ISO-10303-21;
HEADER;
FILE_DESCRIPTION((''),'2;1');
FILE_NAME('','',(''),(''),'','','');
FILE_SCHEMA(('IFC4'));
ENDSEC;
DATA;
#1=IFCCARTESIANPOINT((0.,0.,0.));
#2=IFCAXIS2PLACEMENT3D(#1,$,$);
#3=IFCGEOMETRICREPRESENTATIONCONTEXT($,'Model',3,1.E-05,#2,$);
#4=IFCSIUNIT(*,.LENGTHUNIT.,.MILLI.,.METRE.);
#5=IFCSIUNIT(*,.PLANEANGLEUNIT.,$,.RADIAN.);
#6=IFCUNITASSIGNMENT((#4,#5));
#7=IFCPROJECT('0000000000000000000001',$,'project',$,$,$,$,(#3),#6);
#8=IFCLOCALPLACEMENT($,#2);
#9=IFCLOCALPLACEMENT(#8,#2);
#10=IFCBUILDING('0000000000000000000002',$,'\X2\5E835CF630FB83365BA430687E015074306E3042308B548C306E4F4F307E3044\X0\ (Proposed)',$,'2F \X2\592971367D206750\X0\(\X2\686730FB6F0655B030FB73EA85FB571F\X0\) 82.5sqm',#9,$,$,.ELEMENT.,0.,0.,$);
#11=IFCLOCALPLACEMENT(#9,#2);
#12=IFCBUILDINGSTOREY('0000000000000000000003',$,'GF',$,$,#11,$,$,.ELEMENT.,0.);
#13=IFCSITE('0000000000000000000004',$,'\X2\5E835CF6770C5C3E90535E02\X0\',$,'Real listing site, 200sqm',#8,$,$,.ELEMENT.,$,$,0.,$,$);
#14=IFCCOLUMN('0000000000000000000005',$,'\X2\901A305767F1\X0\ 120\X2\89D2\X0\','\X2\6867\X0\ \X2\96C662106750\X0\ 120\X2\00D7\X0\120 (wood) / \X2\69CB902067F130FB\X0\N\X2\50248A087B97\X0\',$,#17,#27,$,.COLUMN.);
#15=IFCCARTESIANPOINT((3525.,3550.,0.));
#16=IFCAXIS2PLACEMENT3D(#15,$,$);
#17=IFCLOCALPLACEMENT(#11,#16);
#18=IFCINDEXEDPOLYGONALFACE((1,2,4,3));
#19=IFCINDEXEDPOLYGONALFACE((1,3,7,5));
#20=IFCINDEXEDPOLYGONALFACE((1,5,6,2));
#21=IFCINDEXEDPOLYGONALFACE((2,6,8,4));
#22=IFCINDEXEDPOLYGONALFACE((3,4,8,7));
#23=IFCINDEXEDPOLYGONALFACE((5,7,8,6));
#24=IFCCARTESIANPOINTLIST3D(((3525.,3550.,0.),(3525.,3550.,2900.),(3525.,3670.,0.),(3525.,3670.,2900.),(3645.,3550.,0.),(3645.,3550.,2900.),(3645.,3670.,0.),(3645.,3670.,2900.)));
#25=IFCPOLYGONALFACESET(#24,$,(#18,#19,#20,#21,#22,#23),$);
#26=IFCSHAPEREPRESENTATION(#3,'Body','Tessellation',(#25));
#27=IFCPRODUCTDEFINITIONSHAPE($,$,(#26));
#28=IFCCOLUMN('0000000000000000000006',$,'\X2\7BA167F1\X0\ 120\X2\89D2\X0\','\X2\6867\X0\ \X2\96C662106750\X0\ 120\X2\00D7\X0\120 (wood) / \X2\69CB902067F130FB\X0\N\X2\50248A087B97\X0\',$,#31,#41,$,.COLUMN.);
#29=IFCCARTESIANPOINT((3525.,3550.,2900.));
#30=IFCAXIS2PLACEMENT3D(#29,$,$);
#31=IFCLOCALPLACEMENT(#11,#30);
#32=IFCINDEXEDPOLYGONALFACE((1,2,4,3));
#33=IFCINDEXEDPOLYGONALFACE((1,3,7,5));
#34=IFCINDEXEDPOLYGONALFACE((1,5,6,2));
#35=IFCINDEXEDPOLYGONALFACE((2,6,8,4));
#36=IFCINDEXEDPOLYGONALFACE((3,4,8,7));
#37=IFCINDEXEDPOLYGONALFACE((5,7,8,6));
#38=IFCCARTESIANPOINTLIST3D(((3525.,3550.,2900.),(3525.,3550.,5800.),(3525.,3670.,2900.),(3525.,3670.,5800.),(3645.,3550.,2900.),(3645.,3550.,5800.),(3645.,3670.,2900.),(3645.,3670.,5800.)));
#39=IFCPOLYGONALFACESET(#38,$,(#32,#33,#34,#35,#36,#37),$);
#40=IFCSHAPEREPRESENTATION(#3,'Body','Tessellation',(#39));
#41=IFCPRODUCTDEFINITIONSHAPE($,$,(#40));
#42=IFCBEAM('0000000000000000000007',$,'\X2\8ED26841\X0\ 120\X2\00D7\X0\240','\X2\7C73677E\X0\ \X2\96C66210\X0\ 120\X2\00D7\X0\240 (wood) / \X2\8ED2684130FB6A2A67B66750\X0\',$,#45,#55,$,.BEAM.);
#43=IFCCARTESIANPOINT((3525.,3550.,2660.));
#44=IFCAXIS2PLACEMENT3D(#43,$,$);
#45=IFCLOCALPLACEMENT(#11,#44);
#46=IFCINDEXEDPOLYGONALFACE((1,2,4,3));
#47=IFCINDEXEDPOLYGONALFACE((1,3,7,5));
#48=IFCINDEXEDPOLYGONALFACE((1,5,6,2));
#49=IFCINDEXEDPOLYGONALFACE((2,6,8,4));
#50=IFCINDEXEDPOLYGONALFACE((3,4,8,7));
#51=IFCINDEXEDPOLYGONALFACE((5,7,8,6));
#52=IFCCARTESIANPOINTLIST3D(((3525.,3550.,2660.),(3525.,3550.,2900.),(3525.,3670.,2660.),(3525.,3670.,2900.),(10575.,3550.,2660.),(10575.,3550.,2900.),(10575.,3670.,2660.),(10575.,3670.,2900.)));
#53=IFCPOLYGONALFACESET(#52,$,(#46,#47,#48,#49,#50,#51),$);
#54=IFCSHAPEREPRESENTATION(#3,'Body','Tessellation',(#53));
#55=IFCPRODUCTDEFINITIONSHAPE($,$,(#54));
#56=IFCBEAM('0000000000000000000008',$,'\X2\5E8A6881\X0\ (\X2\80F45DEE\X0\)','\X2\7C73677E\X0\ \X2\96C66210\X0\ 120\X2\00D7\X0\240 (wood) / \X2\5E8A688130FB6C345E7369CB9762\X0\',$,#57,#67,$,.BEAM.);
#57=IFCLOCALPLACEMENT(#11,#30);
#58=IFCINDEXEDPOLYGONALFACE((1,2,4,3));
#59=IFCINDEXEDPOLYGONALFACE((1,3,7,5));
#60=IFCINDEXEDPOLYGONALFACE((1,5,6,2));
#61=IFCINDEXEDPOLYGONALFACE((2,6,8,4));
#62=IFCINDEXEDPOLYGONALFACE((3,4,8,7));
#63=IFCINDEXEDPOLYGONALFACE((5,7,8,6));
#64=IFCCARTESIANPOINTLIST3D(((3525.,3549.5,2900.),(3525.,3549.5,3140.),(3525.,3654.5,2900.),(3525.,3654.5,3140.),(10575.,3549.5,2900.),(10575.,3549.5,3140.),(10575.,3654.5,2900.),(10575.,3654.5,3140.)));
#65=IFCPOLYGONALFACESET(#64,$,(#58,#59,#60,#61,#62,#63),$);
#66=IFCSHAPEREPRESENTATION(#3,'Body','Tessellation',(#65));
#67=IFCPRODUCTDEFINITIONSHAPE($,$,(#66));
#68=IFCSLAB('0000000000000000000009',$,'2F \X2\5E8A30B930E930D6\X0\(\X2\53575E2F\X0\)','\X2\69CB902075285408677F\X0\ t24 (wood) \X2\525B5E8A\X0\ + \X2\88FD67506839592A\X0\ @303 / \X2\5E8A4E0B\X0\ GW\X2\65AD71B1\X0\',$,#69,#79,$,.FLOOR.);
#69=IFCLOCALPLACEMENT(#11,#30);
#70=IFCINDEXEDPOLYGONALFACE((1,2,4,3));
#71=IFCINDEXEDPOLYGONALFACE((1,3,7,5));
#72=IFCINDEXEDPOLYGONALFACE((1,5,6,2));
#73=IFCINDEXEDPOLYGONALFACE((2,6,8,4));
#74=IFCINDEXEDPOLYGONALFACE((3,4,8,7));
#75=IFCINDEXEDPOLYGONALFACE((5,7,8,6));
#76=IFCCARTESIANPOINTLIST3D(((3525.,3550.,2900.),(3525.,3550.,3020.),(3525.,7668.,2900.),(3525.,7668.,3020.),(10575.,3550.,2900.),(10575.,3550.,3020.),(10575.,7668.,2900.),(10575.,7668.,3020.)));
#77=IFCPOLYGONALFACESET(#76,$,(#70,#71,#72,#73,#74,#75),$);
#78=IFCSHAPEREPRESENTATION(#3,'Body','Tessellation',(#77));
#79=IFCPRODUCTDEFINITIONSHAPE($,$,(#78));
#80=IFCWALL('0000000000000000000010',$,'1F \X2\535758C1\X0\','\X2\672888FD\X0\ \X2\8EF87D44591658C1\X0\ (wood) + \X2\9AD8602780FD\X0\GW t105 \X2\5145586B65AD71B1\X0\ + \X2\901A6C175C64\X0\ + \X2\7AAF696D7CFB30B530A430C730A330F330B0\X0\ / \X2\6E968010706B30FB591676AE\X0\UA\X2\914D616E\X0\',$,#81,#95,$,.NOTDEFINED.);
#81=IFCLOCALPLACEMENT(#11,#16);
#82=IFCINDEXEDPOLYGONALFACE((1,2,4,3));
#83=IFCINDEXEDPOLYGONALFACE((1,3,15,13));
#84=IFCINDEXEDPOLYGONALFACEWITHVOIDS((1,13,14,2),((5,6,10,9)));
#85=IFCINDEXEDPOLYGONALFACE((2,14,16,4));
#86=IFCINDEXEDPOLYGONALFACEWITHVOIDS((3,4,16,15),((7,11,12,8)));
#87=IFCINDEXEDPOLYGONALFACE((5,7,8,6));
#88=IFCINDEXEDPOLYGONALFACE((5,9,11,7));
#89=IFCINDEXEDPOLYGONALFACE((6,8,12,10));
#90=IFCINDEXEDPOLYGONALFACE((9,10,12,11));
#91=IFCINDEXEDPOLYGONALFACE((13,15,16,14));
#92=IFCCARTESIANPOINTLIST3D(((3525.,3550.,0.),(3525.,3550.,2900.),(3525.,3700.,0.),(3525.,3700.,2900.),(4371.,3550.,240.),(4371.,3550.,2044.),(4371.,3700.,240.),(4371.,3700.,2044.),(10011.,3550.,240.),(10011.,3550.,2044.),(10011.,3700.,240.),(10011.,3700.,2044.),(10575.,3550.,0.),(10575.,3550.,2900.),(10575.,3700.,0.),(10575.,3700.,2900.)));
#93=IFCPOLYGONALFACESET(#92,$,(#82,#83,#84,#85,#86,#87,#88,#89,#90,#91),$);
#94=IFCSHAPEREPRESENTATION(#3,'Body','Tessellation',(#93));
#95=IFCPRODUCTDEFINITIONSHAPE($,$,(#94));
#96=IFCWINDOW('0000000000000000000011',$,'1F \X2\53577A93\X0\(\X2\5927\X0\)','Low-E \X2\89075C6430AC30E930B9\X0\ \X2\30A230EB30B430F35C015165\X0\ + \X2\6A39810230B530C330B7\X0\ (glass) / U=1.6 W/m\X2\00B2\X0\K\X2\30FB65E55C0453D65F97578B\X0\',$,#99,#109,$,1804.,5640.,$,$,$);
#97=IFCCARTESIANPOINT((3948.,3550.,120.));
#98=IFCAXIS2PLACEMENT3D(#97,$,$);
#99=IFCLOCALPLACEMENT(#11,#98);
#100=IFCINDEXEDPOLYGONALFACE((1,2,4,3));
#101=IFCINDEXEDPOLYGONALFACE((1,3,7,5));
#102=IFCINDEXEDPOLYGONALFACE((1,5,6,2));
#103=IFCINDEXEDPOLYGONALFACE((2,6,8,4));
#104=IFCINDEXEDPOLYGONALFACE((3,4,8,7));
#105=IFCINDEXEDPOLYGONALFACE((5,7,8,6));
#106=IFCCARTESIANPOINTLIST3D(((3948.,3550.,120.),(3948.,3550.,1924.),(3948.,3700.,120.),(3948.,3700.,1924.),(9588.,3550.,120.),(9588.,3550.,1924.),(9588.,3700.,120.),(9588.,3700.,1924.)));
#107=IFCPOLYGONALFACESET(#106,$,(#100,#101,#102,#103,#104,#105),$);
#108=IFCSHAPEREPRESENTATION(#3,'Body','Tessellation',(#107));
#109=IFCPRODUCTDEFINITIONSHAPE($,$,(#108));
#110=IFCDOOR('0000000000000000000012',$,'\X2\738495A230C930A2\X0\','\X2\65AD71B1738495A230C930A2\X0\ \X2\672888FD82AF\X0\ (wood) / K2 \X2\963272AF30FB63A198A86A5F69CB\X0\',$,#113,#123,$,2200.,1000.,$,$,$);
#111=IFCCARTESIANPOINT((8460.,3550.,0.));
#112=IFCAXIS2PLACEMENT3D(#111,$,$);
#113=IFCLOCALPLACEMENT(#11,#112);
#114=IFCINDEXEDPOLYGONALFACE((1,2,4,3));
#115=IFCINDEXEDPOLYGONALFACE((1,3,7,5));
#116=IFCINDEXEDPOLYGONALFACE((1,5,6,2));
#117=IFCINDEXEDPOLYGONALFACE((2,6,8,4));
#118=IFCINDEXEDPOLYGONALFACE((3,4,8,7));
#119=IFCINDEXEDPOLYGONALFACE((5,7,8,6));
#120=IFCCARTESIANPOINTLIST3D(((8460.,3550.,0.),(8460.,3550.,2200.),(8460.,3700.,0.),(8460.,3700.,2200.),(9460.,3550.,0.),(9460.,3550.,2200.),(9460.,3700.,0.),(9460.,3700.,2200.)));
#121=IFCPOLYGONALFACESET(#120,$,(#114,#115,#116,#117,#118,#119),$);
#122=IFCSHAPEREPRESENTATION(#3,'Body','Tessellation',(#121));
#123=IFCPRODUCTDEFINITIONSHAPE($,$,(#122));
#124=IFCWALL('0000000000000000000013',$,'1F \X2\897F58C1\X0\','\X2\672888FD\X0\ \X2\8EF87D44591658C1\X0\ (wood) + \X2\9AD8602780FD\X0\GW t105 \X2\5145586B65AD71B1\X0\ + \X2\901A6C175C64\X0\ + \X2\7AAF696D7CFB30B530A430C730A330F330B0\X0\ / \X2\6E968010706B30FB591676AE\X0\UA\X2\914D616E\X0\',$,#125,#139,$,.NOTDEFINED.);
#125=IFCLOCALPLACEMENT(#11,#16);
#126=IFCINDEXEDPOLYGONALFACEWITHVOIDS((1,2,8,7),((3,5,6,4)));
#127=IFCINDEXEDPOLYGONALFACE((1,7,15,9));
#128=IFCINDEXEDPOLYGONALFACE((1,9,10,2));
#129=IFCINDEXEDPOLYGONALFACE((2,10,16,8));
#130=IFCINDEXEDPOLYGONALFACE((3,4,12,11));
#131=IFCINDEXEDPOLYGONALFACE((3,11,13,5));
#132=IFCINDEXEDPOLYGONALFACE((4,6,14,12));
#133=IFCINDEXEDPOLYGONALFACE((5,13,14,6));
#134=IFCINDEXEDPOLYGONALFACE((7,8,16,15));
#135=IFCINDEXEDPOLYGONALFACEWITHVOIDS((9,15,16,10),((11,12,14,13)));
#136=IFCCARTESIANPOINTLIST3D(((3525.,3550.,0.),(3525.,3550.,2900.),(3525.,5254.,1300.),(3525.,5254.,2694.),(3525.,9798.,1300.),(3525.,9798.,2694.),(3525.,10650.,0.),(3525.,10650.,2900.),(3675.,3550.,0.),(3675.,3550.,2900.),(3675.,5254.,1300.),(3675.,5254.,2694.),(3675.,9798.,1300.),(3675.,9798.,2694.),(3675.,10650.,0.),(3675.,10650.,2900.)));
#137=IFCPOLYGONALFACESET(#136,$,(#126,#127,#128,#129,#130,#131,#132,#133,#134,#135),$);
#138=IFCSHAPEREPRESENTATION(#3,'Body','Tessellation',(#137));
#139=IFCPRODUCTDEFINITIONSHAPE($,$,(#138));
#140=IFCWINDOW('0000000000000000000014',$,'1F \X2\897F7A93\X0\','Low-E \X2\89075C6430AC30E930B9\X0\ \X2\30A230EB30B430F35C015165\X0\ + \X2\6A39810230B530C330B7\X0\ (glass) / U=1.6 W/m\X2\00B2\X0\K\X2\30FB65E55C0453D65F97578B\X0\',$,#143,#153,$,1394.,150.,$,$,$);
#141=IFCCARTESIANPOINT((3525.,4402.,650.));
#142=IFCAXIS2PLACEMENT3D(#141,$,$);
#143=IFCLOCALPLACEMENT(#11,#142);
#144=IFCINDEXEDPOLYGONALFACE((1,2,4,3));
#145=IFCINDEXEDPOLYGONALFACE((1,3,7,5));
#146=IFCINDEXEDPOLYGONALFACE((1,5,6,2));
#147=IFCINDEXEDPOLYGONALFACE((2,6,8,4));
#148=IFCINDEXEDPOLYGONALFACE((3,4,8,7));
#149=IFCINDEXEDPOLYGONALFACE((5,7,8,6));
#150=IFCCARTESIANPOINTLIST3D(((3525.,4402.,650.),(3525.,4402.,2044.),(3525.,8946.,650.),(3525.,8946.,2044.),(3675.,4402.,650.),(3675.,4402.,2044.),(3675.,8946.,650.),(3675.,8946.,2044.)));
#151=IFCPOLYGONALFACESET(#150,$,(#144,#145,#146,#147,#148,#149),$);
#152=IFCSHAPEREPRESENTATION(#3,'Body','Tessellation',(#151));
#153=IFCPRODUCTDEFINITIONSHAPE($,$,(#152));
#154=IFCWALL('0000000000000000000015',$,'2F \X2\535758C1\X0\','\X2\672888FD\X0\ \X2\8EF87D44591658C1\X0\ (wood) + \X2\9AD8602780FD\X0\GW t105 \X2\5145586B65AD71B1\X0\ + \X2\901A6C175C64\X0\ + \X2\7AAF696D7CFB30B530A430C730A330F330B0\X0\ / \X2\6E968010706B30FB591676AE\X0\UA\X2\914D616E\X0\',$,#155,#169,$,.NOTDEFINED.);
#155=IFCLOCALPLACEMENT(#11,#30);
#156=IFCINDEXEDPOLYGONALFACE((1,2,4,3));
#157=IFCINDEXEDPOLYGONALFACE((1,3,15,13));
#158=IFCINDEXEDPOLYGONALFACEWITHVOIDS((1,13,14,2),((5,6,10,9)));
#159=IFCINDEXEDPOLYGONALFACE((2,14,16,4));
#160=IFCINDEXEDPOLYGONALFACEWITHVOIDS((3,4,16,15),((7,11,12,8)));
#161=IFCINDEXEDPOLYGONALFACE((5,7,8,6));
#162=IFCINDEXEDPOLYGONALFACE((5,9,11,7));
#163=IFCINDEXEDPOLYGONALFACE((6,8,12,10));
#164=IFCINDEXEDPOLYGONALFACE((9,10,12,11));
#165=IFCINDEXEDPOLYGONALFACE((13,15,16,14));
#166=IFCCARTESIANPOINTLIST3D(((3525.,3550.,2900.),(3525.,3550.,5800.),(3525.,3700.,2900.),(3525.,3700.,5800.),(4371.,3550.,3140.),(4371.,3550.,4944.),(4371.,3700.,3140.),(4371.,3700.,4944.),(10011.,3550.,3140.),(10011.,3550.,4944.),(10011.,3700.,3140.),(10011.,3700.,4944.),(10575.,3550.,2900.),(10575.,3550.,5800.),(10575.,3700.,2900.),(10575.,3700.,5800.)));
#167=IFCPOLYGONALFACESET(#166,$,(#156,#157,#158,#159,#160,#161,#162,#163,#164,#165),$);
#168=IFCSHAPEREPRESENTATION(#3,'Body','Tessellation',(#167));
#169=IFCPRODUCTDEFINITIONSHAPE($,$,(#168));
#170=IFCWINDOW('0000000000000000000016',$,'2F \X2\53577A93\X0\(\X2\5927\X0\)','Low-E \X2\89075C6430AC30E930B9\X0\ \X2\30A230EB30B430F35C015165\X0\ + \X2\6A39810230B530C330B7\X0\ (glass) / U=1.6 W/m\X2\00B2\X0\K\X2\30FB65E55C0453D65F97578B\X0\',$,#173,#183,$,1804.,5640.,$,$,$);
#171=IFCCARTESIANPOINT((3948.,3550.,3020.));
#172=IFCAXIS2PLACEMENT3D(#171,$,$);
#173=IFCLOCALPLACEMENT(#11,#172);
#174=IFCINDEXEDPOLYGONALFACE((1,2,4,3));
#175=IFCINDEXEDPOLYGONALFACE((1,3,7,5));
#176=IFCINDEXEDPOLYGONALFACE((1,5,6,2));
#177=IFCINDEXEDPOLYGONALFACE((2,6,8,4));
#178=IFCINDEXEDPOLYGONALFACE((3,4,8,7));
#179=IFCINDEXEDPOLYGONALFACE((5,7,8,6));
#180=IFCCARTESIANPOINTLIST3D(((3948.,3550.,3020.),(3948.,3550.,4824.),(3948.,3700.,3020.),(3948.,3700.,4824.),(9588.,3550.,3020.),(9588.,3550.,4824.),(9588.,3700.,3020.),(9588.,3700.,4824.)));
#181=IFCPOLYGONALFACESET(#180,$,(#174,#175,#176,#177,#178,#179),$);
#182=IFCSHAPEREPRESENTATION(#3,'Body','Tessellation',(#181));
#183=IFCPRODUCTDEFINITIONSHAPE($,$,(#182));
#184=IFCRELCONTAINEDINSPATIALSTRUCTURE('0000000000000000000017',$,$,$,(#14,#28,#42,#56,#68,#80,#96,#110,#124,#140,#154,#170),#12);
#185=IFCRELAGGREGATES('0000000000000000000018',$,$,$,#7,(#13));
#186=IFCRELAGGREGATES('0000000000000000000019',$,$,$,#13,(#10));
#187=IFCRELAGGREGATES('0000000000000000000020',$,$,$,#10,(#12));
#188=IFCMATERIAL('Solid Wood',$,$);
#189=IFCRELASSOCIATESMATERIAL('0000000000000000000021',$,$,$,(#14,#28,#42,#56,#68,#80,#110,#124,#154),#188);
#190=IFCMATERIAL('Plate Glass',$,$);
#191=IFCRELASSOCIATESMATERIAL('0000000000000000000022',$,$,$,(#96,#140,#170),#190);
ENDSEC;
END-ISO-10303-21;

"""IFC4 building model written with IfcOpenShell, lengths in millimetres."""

from ifc_helpers import new_model, si_unit, frame, frame_2d, origin, place, context, project, spatial, rectangle, extrude, material, element, fill, save


model = new_model("IFC4")

# Units and contexts
model_context = context("Model", 3, precision=1e-05, world=origin())
ifc_project = project(units=[si_unit("LENGTHUNIT", "METRE", prefix="MILLI"), si_unit("PLANEANGLEUNIT", "RADIAN")], contexts=[model_context])

# Site, building, storey
site_placement = place(None, origin())
site = spatial("IfcSite", under=ifc_project, at=site_placement, Name="広島県尾道市", ObjectType="Real listing site, 200sqm", CompositionType="ELEMENT", RefElevation=0.0)
building_placement = place(site_placement, origin())
building = spatial("IfcBuilding", under=site, at=building_placement, Name="広島・茶室と縁側のある和の住まい (Proposed)", ObjectType="2F 天然素材(桧・漆喰・珪藻土) 82.5sqm", CompositionType="ELEMENT", ElevationOfRefHeight=0.0, ElevationOfTerrain=0.0)
storey_placement = place(building_placement, origin())
storey = spatial("IfcBuildingStorey", under=building, at=storey_placement, Name="GF", CompositionType="ELEMENT", Elevation=0.0)

# Columns
ifc_material_1 = material(Name="Solid Wood")
column_1_placement = place(storey_placement, frame((3525.0, 3550.0, 0.0)))
element("IfcColumn", 1, at=column_1_placement, inside=storey, material=ifc_material_1, Name="通し柱 120角", Description="桧 集成材 120×120 (wood) / 構造柱・N値計算", PredefinedType="COLUMN", context=model_context, shape_type="SweptSolid", body=[
    extrude(rectangle(XDim=120.0, YDim=120.0, at=frame_2d((60.0, 60.0))), frame((3525.0, 3550.0, 0.0)), (0.0, 0.0, 1.0), 2900.0),
])
column_2_placement = place(storey_placement, frame((3525.0, 3550.0, 2900.0)))
element("IfcColumn", 2, at=column_2_placement, inside=storey, material=ifc_material_1, Name="管柱 120角", Description="桧 集成材 120×120 (wood) / 構造柱・N値計算", PredefinedType="COLUMN", context=model_context, shape_type="SweptSolid", body=[
    extrude(rectangle(XDim=120.0, YDim=120.0, at=frame_2d((60.0, 60.0))), frame((3525.0, 3550.0, 2900.0)), (0.0, 0.0, 1.0), 2900.0),
])

# Beams
beam_1_placement = place(storey_placement, frame((3525.0, 3550.0, 2660.0)))
element("IfcBeam", 3, at=beam_1_placement, inside=storey, material=ifc_material_1, Name="軒桁 120×240", Description="米松 集成 120×240 (wood) / 軒桁・横架材", PredefinedType="BEAM", context=model_context, shape_type="SweptSolid", body=[
    extrude(rectangle(XDim=7050.0, YDim=120.0, at=frame_2d((3525.0, 60.0))), frame((3525.0, 3550.0, 2660.0)), (0.0, 0.0, 1.0), 240.0),
])
beam_2_placement = place(storey_placement, frame((3525.0, 3550.0, 2900.0)))
element("IfcBeam", 4, at=beam_2_placement, inside=storey, material=ifc_material_1, Name="床梁 (胴差)", Description="米松 集成 120×240 (wood) / 床梁・水平構面", PredefinedType="BEAM", context=model_context, shape_type="SweptSolid", body=[
    extrude(rectangle(XDim=7050.0, YDim=105.0, at=frame_2d((3525.0, 52.0))), frame((3525.0, 3550.0, 2900.0)), (0.0, 0.0, 1.0), 240.0),
])

# Slab
slab_1_placement = place(storey_placement, frame((3525.0, 3550.0, 2900.0)))
element("IfcSlab", 5, at=slab_1_placement, inside=storey, material=ifc_material_1, Name="2F 床スラブ(南帯)", Description="構造用合板 t24 (wood) 剛床 + 製材根太 @303 / 床下 GW断熱", PredefinedType="FLOOR", context=model_context, shape_type="SweptSolid", body=[
    extrude(rectangle(XDim=7050.0, YDim=4118.0, at=frame_2d((3525.0, 2059.0))), frame((3525.0, 3550.0, 2900.0)), (0.0, 0.0, 1.0), 120.0),
])

# Wall, openings, window, door
wall_1_placement = place(storey_placement, frame((3525.0, 3550.0, 0.0)))
wall_1 = element("IfcWall", 6, at=wall_1_placement, inside=storey, material=ifc_material_1, Name="1F 南壁", Description="木製 軸組外壁 (wood) + 高性能GW t105 充填断熱 + 通気層 + 窯業系サイディング / 準耐火・外皮UA配慮", PredefinedType="NOTDEFINED", context=model_context, shape_type="SweptSolid", body=[
    extrude(rectangle(XDim=7050.0, YDim=150.0, at=frame_2d((3525.0, 75.0))), frame((3525.0, 3550.0, 0.0)), (0.0, 0.0, 1.0), 2900.0),
])
opening_1_placement = place(storey_placement, frame((3948.0, 3550.0, 120.0)))
opening_1 = element("IfcOpeningElement", 7, at=opening_1_placement, cuts=wall_1, PredefinedType="NOTDEFINED", context=model_context, shape_type="SweptSolid", body=[
    extrude(rectangle(XDim=5640.0, YDim=150.0, at=frame_2d((2820.0, 75.0))), frame((3948.0, 3550.0, 120.0)), (0.0, 0.0, 1.0), 1804.0),
])
opening_2_placement = place(storey_placement, frame((8460.0, 3550.0, 0.0)))
opening_2 = element("IfcOpeningElement", 8, at=opening_2_placement, cuts=wall_1, PredefinedType="NOTDEFINED", context=model_context, shape_type="SweptSolid", body=[
    extrude(rectangle(XDim=1000.0, YDim=150.0, at=frame_2d((500.0, 75.0))), frame((8460.0, 3550.0, 0.0)), (0.0, 0.0, 1.0), 2200.0),
])
ifc_material_2 = material(Name="Plate Glass")
window_1_placement = place(storey_placement, frame((3948.0, 3550.0, 120.0)))
window_1 = element("IfcWindow", 9, at=window_1_placement, inside=storey, material=ifc_material_2, Name="1F 南窓(大)", Description="Low-E 複層ガラス アルゴン封入 + 樹脂サッシ (glass) / U=1.6 W/m²K・日射取得型", OverallHeight=1804.0, OverallWidth=5640.0, context=model_context, shape_type="SweptSolid", body=[
    extrude(rectangle(XDim=5640.0, YDim=150.0, at=frame_2d((2820.0, 75.0))), frame((3948.0, 3550.0, 120.0)), (0.0, 0.0, 1.0), 1804.0),
])
fill(opening_1, window_1)
door_placement = place(storey_placement, frame((8460.0, 3550.0, 0.0)))
door = element("IfcDoor", 10, at=door_placement, inside=storey, material=ifc_material_1, Name="玄関ドア", Description="断熱玄関ドア 木製芯 (wood) / K2 防犯・採風機構", OverallHeight=2200.0, OverallWidth=1000.0, context=model_context, shape_type="SweptSolid", body=[
    extrude(rectangle(XDim=1000.0, YDim=150.0, at=frame_2d((500.0, 75.0))), frame((8460.0, 3550.0, 0.0)), (0.0, 0.0, 1.0), 2200.0),
])
fill(opening_2, door)

# Walls, openings, windows
wall_2_placement = place(storey_placement, frame((3525.0, 3550.0, 0.0)))
wall_2 = element("IfcWall", 11, at=wall_2_placement, inside=storey, material=ifc_material_1, Name="1F 西壁", Description="木製 軸組外壁 (wood) + 高性能GW t105 充填断熱 + 通気層 + 窯業系サイディング / 準耐火・外皮UA配慮", PredefinedType="NOTDEFINED", context=model_context, shape_type="SweptSolid", body=[
    extrude(rectangle(XDim=150.0, YDim=7100.0, at=frame_2d((75.0, 3550.0))), frame((3525.0, 3550.0, 0.0)), (0.0, 0.0, 1.0), 2900.0),
])
opening_3_placement = place(storey_placement, frame((3525.0, 4402.0, 650.0)))
opening_3 = element("IfcOpeningElement", 12, at=opening_3_placement, cuts=wall_2, PredefinedType="NOTDEFINED", context=model_context, shape_type="SweptSolid", body=[
    extrude(rectangle(XDim=150.0, YDim=4544.0, at=frame_2d((75.0, 2272.0))), frame((3525.0, 4402.0, 650.0)), (0.0, 0.0, 1.0), 1394.0),
])
window_2_placement = place(storey_placement, frame((3525.0, 4402.0, 650.0)))
window_2 = element("IfcWindow", 13, at=window_2_placement, inside=storey, material=ifc_material_2, Name="1F 西窓", Description="Low-E 複層ガラス アルゴン封入 + 樹脂サッシ (glass) / U=1.6 W/m²K・日射取得型", OverallHeight=1394.0, OverallWidth=150.0, context=model_context, shape_type="SweptSolid", body=[
    extrude(rectangle(XDim=150.0, YDim=4544.0, at=frame_2d((75.0, 2272.0))), frame((3525.0, 4402.0, 650.0)), (0.0, 0.0, 1.0), 1394.0),
])
fill(opening_3, window_2)
wall_3_placement = place(storey_placement, frame((3525.0, 3550.0, 2900.0)))
wall_3 = element("IfcWall", 14, at=wall_3_placement, inside=storey, material=ifc_material_1, Name="2F 南壁", Description="木製 軸組外壁 (wood) + 高性能GW t105 充填断熱 + 通気層 + 窯業系サイディング / 準耐火・外皮UA配慮", PredefinedType="NOTDEFINED", context=model_context, shape_type="SweptSolid", body=[
    extrude(rectangle(XDim=7050.0, YDim=150.0, at=frame_2d((3525.0, 75.0))), frame((3525.0, 3550.0, 2900.0)), (0.0, 0.0, 1.0), 2900.0),
])
opening_4_placement = place(storey_placement, frame((3948.0, 3550.0, 3020.0)))
opening_4 = element("IfcOpeningElement", 15, at=opening_4_placement, cuts=wall_3, PredefinedType="NOTDEFINED", context=model_context, shape_type="SweptSolid", body=[
    extrude(rectangle(XDim=5640.0, YDim=150.0, at=frame_2d((2820.0, 75.0))), frame((3948.0, 3550.0, 3020.0)), (0.0, 0.0, 1.0), 1804.0),
])
window_3_placement = place(storey_placement, frame((3948.0, 3550.0, 3020.0)))
window_3 = element("IfcWindow", 16, at=window_3_placement, inside=storey, material=ifc_material_2, Name="2F 南窓(大)", Description="Low-E 複層ガラス アルゴン封入 + 樹脂サッシ (glass) / U=1.6 W/m²K・日射取得型", OverallHeight=1804.0, OverallWidth=5640.0, context=model_context, shape_type="SweptSolid", body=[
    extrude(rectangle(XDim=5640.0, YDim=150.0, at=frame_2d((2820.0, 75.0))), frame((3948.0, 3550.0, 3020.0)), (0.0, 0.0, 1.0), 1804.0),
])
fill(opening_4, window_3)

save(model, "model.ifc")
